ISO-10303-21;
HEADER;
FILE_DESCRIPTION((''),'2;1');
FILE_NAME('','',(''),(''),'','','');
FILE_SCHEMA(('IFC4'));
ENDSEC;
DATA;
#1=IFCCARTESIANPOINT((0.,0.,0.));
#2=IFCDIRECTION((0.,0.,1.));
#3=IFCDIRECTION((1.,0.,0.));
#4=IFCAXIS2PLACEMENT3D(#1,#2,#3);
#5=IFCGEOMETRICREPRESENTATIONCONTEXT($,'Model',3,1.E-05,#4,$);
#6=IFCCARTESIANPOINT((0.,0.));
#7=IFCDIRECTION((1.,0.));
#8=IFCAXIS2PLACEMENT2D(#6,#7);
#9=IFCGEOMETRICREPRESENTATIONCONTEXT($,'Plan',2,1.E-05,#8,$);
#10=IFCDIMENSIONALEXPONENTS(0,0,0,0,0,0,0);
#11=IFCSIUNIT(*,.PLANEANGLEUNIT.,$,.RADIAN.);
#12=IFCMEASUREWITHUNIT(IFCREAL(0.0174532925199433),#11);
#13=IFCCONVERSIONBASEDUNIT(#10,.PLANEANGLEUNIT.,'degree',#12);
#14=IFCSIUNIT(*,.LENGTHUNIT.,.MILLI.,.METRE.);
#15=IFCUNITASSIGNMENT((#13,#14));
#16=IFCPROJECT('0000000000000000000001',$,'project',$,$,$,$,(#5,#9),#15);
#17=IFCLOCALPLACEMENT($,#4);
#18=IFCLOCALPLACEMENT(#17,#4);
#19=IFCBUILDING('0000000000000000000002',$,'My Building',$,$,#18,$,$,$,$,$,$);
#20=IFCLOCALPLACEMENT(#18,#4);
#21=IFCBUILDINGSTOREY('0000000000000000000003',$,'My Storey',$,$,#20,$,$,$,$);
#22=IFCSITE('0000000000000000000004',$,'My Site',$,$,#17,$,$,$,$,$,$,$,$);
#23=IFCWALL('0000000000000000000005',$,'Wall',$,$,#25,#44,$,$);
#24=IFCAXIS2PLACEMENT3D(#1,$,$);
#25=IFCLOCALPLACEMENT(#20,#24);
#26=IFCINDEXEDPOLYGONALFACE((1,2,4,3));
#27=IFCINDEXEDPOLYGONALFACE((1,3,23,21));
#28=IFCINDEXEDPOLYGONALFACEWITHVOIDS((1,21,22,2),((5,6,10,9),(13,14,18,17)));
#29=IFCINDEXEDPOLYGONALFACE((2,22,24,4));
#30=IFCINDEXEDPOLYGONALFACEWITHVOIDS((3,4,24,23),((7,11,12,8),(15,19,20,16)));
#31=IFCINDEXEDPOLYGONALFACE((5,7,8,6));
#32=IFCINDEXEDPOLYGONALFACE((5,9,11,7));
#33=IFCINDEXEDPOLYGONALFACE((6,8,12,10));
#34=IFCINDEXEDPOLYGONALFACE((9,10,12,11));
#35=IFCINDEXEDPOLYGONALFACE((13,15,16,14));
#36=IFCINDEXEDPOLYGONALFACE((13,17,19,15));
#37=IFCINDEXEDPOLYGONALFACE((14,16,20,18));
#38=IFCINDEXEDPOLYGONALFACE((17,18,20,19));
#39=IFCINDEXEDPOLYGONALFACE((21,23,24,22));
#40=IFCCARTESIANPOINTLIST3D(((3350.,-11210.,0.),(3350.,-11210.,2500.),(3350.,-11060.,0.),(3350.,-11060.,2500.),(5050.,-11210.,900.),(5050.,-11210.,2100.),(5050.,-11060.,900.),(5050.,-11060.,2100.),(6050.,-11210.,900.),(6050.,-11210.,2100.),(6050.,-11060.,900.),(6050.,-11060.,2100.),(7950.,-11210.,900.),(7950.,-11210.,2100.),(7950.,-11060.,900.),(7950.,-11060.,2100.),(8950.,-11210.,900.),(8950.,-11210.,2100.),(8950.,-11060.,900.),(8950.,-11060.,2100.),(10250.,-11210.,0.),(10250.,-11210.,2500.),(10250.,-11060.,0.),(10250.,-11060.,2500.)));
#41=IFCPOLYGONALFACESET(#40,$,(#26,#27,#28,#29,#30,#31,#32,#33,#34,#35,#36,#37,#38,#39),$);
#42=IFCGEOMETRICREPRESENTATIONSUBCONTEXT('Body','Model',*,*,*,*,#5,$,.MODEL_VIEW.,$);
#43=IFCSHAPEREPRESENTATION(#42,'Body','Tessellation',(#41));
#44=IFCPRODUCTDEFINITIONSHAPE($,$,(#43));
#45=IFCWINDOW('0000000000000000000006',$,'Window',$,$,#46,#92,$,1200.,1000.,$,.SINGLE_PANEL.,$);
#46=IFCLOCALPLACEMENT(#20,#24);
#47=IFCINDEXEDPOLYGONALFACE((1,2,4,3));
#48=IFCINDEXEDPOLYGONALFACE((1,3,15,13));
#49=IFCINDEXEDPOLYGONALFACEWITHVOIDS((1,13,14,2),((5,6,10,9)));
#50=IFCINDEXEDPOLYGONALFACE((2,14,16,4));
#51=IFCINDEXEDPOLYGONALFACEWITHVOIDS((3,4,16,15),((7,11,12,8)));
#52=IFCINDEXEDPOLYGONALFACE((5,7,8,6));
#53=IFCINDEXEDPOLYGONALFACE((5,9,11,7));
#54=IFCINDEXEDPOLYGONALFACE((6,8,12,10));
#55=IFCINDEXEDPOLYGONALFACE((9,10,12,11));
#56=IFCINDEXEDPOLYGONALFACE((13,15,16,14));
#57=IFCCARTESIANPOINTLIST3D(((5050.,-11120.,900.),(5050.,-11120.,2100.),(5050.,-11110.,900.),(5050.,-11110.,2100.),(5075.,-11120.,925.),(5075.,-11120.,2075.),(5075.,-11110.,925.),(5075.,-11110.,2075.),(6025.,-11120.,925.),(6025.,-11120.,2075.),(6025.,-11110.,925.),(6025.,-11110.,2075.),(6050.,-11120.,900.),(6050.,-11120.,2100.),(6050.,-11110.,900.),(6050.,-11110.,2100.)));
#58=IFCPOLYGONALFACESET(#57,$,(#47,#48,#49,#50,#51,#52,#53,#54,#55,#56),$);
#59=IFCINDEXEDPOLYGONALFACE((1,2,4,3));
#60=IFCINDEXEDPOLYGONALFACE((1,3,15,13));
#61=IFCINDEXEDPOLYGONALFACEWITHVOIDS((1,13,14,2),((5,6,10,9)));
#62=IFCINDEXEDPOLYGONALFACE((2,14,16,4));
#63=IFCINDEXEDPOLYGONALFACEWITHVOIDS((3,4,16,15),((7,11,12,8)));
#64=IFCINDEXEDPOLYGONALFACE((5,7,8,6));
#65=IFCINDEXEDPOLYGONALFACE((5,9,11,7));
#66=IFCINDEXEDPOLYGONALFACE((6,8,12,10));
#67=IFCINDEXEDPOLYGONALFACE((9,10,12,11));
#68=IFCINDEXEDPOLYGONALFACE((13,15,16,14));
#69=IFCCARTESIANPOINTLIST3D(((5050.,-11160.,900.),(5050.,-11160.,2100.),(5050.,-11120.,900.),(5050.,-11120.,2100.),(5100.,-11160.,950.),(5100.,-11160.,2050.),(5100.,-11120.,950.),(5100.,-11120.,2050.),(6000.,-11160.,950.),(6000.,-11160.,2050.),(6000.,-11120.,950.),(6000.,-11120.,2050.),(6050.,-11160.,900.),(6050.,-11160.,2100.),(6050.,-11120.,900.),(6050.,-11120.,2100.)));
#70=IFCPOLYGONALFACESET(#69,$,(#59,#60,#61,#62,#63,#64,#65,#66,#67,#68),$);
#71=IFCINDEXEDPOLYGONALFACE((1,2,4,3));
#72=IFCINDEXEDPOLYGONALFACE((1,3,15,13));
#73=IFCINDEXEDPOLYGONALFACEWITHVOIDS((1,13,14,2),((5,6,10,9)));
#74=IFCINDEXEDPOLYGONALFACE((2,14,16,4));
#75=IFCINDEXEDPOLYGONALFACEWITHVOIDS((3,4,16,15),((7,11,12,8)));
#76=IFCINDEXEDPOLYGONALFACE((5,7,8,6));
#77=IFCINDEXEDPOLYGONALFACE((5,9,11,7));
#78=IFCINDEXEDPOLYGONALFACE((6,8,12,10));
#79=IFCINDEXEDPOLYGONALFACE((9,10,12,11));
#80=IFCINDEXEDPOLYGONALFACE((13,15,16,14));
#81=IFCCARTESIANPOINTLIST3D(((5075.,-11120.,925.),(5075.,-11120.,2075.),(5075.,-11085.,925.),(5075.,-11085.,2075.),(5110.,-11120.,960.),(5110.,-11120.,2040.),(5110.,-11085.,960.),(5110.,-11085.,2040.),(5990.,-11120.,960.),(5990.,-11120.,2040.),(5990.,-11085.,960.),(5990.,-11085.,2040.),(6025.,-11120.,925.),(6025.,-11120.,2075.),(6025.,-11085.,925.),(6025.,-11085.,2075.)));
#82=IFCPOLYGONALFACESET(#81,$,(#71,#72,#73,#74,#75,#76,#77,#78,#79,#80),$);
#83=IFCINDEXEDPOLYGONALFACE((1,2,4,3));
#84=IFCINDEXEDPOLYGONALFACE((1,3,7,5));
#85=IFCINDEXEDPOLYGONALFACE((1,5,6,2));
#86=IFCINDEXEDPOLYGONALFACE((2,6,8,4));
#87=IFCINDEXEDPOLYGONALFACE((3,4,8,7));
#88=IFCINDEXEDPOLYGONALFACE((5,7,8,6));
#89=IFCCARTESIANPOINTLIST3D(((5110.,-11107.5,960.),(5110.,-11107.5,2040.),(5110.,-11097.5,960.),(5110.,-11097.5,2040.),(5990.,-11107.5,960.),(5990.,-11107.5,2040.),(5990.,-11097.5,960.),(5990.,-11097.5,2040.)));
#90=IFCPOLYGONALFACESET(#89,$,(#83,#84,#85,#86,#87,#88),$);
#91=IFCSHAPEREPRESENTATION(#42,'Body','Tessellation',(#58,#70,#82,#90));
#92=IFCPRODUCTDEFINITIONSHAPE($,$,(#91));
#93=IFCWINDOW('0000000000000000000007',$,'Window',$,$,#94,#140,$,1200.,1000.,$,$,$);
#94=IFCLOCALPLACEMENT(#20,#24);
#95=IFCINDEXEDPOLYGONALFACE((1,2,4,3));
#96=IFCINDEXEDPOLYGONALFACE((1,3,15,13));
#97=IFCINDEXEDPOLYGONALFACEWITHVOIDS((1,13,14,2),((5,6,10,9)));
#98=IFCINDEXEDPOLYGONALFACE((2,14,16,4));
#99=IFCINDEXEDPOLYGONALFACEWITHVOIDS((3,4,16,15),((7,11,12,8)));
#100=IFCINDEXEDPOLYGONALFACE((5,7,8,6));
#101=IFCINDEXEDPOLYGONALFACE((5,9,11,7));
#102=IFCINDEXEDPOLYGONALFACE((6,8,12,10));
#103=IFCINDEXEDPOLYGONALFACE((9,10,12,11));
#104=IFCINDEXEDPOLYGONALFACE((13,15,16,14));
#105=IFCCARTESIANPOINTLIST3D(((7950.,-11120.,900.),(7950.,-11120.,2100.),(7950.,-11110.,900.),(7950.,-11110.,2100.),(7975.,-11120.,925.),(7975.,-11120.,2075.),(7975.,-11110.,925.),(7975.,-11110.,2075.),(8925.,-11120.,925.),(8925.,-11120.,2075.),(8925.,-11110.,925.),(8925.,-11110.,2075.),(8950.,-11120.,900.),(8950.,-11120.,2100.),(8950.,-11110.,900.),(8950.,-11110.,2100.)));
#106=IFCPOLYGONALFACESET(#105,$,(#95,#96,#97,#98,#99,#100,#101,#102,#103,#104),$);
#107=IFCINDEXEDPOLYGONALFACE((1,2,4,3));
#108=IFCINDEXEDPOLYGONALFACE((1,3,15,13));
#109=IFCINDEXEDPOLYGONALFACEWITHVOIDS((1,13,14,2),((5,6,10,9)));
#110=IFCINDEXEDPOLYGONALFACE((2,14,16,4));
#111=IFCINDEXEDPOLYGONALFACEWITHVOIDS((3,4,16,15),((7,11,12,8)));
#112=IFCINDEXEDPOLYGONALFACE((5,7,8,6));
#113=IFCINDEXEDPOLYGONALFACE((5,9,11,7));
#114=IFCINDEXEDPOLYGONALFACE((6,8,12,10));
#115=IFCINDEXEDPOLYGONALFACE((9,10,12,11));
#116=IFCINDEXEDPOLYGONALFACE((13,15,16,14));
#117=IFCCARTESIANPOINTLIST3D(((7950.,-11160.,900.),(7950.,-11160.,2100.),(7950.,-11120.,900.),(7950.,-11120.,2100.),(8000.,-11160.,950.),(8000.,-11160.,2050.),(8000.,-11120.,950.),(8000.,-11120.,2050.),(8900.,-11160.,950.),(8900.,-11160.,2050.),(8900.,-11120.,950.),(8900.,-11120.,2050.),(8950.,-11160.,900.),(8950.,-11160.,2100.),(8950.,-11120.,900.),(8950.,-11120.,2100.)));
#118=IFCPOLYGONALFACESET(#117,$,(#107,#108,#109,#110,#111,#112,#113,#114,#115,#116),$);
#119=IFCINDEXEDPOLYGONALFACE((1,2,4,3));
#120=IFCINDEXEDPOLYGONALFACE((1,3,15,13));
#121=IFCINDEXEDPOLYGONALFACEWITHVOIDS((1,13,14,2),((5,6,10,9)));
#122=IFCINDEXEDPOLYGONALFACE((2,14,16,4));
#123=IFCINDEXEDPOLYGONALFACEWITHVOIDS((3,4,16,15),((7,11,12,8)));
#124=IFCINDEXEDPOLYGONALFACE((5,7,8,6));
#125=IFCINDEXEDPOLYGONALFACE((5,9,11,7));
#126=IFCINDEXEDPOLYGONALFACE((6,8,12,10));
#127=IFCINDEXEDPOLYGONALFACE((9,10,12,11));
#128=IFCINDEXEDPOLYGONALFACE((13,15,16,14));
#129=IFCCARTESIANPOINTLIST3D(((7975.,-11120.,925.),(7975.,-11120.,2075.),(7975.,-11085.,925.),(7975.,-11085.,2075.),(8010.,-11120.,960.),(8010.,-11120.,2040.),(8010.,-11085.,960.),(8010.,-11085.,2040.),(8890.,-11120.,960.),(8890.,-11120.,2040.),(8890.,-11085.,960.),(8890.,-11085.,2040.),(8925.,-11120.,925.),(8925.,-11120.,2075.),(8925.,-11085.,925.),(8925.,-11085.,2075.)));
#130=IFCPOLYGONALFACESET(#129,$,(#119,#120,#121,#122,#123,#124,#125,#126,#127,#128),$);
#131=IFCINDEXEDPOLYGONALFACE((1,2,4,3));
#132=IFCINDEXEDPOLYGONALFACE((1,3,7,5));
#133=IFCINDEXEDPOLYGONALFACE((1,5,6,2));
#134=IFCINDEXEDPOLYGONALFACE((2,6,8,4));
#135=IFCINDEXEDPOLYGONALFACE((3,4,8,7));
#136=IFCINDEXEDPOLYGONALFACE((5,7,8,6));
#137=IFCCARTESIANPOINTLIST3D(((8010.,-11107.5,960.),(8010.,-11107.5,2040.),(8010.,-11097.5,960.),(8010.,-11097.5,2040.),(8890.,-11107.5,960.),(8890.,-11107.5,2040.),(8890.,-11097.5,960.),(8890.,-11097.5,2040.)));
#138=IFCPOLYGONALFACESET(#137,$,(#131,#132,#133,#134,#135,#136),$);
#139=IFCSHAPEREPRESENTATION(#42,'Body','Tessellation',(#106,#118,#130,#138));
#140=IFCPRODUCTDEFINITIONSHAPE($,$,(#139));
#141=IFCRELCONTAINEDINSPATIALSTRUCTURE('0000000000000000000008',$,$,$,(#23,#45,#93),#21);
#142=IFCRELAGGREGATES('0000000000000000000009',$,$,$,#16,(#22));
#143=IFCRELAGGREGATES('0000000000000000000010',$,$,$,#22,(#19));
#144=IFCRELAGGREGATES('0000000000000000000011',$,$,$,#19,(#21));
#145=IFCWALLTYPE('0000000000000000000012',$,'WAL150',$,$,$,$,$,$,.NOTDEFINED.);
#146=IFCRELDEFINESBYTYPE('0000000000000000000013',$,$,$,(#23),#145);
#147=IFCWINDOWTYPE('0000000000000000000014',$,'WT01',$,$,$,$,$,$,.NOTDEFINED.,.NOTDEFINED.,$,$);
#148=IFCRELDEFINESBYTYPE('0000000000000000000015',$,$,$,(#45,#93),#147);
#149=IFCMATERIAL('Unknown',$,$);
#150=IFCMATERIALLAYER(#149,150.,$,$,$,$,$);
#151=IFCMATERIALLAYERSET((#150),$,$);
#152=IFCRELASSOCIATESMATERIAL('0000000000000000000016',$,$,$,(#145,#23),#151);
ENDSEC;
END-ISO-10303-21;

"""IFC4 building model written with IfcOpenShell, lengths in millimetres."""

from ifc_helpers import new_model, entity, si_unit, converted_unit, frame, origin_with_axes, origin_2d_with_axis, place, context, subcontext, project, spatial, line, indexed_curve, outline, extrude, shape, source, transform, mapped, material, layer, layer_set, layer_usage, type_object, type_shapes, element, fill, save


model = new_model("IFC4")

# Units and contexts
model_context = context("Model", 3, precision=1e-05, world=origin_with_axes())
plan_context = context("Plan", 2, precision=1e-05, world=origin_2d_with_axis())
body_context_1 = subcontext(model_context, "Body", "Model", "MODEL_VIEW")
body_context_2 = subcontext(plan_context, "Body", "Plan", "PLAN_VIEW")
ifc_project = project(units=[converted_unit("PLANEANGLEUNIT", "degree", entity("IfcReal", 0.0174532925199433), si_unit("PLANEANGLEUNIT", "RADIAN"), dimensions=[0, 0, 0, 0, 0, 0, 0]), si_unit("LENGTHUNIT", "METRE", prefix="MILLI")], contexts=[model_context, plan_context])

# Site, building, storey
site_placement = place(None, origin_with_axes())
site = spatial("IfcSite", under=ifc_project, at=site_placement, Name="My Site")
building_placement = place(site_placement, origin_with_axes())
building = spatial("IfcBuilding", under=site, at=building_placement, Name="My Building")
storey_placement = place(building_placement, origin_with_axes())
storey = spatial("IfcBuildingStorey", under=building, at=storey_placement, Name="My Storey")

# Shared definitions
ifc_material = material(Name="Unknown")

# Shared definitions
ifc_layer_1 = layer(ifc_material, 150.0)
ifc_layer_set_1 = layer_set([ifc_layer_1])
wall_type_1 = type_object("IfcWallType", Name="WAL150", PredefinedType="NOTDEFINED", material=ifc_layer_set_1)

# Wall, openings, windows
ifc_layer_usage_1 = layer_usage(ifc_layer_set_1, "AXIS2", "POSITIVE", 0.0)
wall_1_placement = place(storey_placement, frame((3350.0, -11210.0, 0.0), z_axis=(0.0, 0.0, 1.0), x_axis=(1.0, 0.0, 0.0)))
wall_1 = element("IfcWall", 1, at=wall_1_placement, inside=storey, type_object=wall_type_1, material=ifc_layer_usage_1, Name="Wall", context=body_context_1, shape_type="SweptSolid", body=[
    extrude(outline(indexed_curve([(0.0, 0.0), (0.0, 150.0), (6900.0, 150.0), (6900.0, 0.0)], segments=[line(1, 2, 3, 4, 1)])), origin_with_axes(), (0.0, 0.0, 1.0), 2500.0),
])
shared_shape_1 = source(origin_with_axes(), body_context_1, "Body", "SweptSolid", [
    extrude(outline(indexed_curve([(0.0, 0.0), (1000.0, 0.0), (1000.0, 1200.0), (0.0, 1200.0)], segments=[line(1, 2, 3, 4, 1)])), frame((0.0, -600.0, 0.0), z_axis=(0.0, -1.0, 0.0), x_axis=(1.0, 0.0, 0.0)), (0.0, 0.0, -1.0), 1200.0),
])
opening_1_placement = place(wall_1_placement, frame((1700.0, 0.0, 900.0), z_axis=(0.0, 0.0, 1.0), x_axis=(1.0, 0.0, 0.0)))
opening_1 = element("IfcOpeningElement", 2, at=opening_1_placement, cuts=wall_1, PredefinedType="OPENING", context=body_context_1, shape_type="MappedRepresentation", body=[
    mapped(shared_shape_1, transform((0.0, 0.0, 0.0), x_axis=(1.0, 0.0, 0.0), y_axis=(0.0, 1.0, 0.0), z_axis=(0.0, 0.0, 1.0), scale=1.0)),
])
opening_2_placement = place(wall_1_placement, frame((4600.0, 0.0, 900.0), z_axis=(0.0, 0.0, 1.0), x_axis=(1.0, 0.0, 0.0)))
opening_2 = element("IfcOpeningElement", 3, at=opening_2_placement, cuts=wall_1, PredefinedType="OPENING", context=body_context_1, shape_type="MappedRepresentation", body=[
    mapped(shared_shape_1, transform((0.0, 0.0, 0.0), x_axis=(1.0, 0.0, 0.0), y_axis=(0.0, 1.0, 0.0), z_axis=(0.0, 0.0, 1.0), scale=1.0)),
])
window_type = type_object("IfcWindowType", Name="WT01", PartitioningType="NOTDEFINED", PredefinedType="NOTDEFINED")
shared_shape_2 = source(origin_with_axes(), body_context_1, "Body", "SweptSolid", [
    extrude(outline(indexed_curve([(0.0, 0.0), (1000.0, 0.0), (1000.0, 1200.0), (0.0, 1200.0)], segments=[line(1, 2, 3, 4, 1)]), holes=[indexed_curve([(25.0, 25.0), (975.0, 25.0), (975.0, 1175.0), (25.0, 1175.0)], segments=[line(1, 2, 3, 4, 1)])]), frame((0.0, 90.0, 0.0), z_axis=(0.0, -1.0, 0.0), x_axis=(1.0, 0.0, 0.0)), (0.0, 0.0, -1.0), 10.0),
    extrude(outline(indexed_curve([(0.0, 0.0), (1000.0, 0.0), (1000.0, 1200.0), (0.0, 1200.0)], segments=[line(1, 2, 3, 4, 1)]), holes=[indexed_curve([(50.0, 50.0), (950.0, 50.0), (950.0, 1150.0), (50.0, 1150.0)], segments=[line(1, 2, 3, 4, 1)])]), frame((0.0, 50.0, 0.0), z_axis=(0.0, -1.0, 0.0), x_axis=(1.0, 0.0, 0.0)), (0.0, 0.0, -1.0), 40.0),
    extrude(outline(indexed_curve([(0.0, 0.0), (950.0, 0.0), (950.0, 1150.0), (0.0, 1150.0)], segments=[line(1, 2, 3, 4, 1)]), holes=[indexed_curve([(35.0, 35.0), (915.0, 35.0), (915.0, 1115.0), (35.0, 1115.0)], segments=[line(1, 2, 3, 4, 1)])]), frame((25.0, 90.0, 25.0), z_axis=(0.0, -1.0, 0.0), x_axis=(1.0, 0.0, 0.0)), (0.0, 0.0, -1.0), 35.0),
    extrude(outline(indexed_curve([(35.0, 35.0), (915.0, 35.0), (915.0, 1115.0), (35.0, 1115.0)], segments=[line(1, 2, 3, 4, 1)])), frame((25.0, 102.5, 25.0), z_axis=(0.0, -1.0, 0.0), x_axis=(1.0, 0.0, 0.0)), (0.0, 0.0, -1.0), 10.0),
])
shared_shape_3 = source(origin_with_axes(), body_context_2, "Body", "Curve2D", [
    entity("IfcIndexedPolyCurve", entity("IfcCartesianPointList2D", [[50.0, 50.0], [950.0, 50.0]])),
    entity("IfcIndexedPolyCurve", entity("IfcCartesianPointList2D", [[0.0, 100.0], [25.0, 100.0], [25.0, 90.0], [50.0, 90.0], [50.0, 50.0], [0.0, 50.0]]), [entity("IfcLineIndex", [1, 2, 3, 4, 5, 6, 1])]),
    entity("IfcIndexedPolyCurve", entity("IfcCartesianPointList2D", [[1000.0, 100.0], [975.0, 100.0], [975.0, 90.0], [950.0, 90.0], [950.0, 50.0], [1000.0, 50.0]]), [entity("IfcLineIndex", [1, 2, 3, 4, 5, 6, 1])]),
    entity("IfcIndexedPolyCurve", entity("IfcCartesianPointList2D", [[25.0, 90.0], [60.0, 90.0], [60.0, 125.0], [25.0, 125.0]]), [entity("IfcLineIndex", [1, 2, 3, 4, 1])]),
    entity("IfcIndexedPolyCurve", entity("IfcCartesianPointList2D", [[975.0, 90.0], [940.0, 90.0], [940.0, 125.0], [975.0, 125.0]]), [entity("IfcLineIndex", [1, 2, 3, 4, 1])]),
    entity("IfcIndexedPolyCurve", entity("IfcCartesianPointList2D", [[60.0, 90.0], [940.0, 90.0]])),
    entity("IfcIndexedPolyCurve", entity("IfcCartesianPointList2D", [[60.0, 125.0], [940.0, 125.0]])),
    entity("IfcIndexedPolyCurve", entity("IfcCartesianPointList2D", [[60.0, 107.5], [940.0, 107.5]])),
])
type_shapes(window_type, [shared_shape_2, shared_shape_3])
window_1_placement = place(opening_1_placement, origin_with_axes())
window_1 = element("IfcWindow", 4, at=window_1_placement, inside=storey, type_object=window_type, Name="Window", OverallHeight=1200.0, OverallWidth=1000.0, PartitioningType="SINGLE_PANEL", shapes=[
    shape(body_context_1, "Body", "MappedRepresentation", [mapped(shared_shape_2, transform((0.0, 0.0, 0.0), x_axis=(1.0, 0.0, 0.0), y_axis=(0.0, 1.0, 0.0), z_axis=(0.0, 0.0, 1.0), scale=1.0))]),
    shape(body_context_2, "Body", "MappedRepresentation", [mapped(shared_shape_3, transform((0.0, 0.0, 0.0), x_axis=(1.0, 0.0, 0.0), y_axis=(0.0, 1.0, 0.0), z_axis=(0.0, 0.0, 1.0), scale=1.0))]),
])
fill(opening_1, window_1)
window_2_placement = place(opening_2_placement, origin_with_axes())
window_2 = element("IfcWindow", 5, at=window_2_placement, inside=storey, type_object=window_type, Name="Window", OverallHeight=1200.0, OverallWidth=1000.0, shapes=[
    shape(body_context_1, "Body", "MappedRepresentation", [mapped(shared_shape_2, transform((0.0, 0.0, 0.0), x_axis=(1.0, 0.0, 0.0), y_axis=(0.0, 1.0, 0.0), z_axis=(0.0, 0.0, 1.0), scale=1.0))]),
    shape(body_context_2, "Body", "MappedRepresentation", [mapped(shared_shape_3, transform((0.0, 0.0, 0.0), x_axis=(1.0, 0.0, 0.0), y_axis=(0.0, 1.0, 0.0), z_axis=(0.0, 0.0, 1.0), scale=1.0))]),
])
fill(opening_2, window_2)

save(model, "model.ifc")
